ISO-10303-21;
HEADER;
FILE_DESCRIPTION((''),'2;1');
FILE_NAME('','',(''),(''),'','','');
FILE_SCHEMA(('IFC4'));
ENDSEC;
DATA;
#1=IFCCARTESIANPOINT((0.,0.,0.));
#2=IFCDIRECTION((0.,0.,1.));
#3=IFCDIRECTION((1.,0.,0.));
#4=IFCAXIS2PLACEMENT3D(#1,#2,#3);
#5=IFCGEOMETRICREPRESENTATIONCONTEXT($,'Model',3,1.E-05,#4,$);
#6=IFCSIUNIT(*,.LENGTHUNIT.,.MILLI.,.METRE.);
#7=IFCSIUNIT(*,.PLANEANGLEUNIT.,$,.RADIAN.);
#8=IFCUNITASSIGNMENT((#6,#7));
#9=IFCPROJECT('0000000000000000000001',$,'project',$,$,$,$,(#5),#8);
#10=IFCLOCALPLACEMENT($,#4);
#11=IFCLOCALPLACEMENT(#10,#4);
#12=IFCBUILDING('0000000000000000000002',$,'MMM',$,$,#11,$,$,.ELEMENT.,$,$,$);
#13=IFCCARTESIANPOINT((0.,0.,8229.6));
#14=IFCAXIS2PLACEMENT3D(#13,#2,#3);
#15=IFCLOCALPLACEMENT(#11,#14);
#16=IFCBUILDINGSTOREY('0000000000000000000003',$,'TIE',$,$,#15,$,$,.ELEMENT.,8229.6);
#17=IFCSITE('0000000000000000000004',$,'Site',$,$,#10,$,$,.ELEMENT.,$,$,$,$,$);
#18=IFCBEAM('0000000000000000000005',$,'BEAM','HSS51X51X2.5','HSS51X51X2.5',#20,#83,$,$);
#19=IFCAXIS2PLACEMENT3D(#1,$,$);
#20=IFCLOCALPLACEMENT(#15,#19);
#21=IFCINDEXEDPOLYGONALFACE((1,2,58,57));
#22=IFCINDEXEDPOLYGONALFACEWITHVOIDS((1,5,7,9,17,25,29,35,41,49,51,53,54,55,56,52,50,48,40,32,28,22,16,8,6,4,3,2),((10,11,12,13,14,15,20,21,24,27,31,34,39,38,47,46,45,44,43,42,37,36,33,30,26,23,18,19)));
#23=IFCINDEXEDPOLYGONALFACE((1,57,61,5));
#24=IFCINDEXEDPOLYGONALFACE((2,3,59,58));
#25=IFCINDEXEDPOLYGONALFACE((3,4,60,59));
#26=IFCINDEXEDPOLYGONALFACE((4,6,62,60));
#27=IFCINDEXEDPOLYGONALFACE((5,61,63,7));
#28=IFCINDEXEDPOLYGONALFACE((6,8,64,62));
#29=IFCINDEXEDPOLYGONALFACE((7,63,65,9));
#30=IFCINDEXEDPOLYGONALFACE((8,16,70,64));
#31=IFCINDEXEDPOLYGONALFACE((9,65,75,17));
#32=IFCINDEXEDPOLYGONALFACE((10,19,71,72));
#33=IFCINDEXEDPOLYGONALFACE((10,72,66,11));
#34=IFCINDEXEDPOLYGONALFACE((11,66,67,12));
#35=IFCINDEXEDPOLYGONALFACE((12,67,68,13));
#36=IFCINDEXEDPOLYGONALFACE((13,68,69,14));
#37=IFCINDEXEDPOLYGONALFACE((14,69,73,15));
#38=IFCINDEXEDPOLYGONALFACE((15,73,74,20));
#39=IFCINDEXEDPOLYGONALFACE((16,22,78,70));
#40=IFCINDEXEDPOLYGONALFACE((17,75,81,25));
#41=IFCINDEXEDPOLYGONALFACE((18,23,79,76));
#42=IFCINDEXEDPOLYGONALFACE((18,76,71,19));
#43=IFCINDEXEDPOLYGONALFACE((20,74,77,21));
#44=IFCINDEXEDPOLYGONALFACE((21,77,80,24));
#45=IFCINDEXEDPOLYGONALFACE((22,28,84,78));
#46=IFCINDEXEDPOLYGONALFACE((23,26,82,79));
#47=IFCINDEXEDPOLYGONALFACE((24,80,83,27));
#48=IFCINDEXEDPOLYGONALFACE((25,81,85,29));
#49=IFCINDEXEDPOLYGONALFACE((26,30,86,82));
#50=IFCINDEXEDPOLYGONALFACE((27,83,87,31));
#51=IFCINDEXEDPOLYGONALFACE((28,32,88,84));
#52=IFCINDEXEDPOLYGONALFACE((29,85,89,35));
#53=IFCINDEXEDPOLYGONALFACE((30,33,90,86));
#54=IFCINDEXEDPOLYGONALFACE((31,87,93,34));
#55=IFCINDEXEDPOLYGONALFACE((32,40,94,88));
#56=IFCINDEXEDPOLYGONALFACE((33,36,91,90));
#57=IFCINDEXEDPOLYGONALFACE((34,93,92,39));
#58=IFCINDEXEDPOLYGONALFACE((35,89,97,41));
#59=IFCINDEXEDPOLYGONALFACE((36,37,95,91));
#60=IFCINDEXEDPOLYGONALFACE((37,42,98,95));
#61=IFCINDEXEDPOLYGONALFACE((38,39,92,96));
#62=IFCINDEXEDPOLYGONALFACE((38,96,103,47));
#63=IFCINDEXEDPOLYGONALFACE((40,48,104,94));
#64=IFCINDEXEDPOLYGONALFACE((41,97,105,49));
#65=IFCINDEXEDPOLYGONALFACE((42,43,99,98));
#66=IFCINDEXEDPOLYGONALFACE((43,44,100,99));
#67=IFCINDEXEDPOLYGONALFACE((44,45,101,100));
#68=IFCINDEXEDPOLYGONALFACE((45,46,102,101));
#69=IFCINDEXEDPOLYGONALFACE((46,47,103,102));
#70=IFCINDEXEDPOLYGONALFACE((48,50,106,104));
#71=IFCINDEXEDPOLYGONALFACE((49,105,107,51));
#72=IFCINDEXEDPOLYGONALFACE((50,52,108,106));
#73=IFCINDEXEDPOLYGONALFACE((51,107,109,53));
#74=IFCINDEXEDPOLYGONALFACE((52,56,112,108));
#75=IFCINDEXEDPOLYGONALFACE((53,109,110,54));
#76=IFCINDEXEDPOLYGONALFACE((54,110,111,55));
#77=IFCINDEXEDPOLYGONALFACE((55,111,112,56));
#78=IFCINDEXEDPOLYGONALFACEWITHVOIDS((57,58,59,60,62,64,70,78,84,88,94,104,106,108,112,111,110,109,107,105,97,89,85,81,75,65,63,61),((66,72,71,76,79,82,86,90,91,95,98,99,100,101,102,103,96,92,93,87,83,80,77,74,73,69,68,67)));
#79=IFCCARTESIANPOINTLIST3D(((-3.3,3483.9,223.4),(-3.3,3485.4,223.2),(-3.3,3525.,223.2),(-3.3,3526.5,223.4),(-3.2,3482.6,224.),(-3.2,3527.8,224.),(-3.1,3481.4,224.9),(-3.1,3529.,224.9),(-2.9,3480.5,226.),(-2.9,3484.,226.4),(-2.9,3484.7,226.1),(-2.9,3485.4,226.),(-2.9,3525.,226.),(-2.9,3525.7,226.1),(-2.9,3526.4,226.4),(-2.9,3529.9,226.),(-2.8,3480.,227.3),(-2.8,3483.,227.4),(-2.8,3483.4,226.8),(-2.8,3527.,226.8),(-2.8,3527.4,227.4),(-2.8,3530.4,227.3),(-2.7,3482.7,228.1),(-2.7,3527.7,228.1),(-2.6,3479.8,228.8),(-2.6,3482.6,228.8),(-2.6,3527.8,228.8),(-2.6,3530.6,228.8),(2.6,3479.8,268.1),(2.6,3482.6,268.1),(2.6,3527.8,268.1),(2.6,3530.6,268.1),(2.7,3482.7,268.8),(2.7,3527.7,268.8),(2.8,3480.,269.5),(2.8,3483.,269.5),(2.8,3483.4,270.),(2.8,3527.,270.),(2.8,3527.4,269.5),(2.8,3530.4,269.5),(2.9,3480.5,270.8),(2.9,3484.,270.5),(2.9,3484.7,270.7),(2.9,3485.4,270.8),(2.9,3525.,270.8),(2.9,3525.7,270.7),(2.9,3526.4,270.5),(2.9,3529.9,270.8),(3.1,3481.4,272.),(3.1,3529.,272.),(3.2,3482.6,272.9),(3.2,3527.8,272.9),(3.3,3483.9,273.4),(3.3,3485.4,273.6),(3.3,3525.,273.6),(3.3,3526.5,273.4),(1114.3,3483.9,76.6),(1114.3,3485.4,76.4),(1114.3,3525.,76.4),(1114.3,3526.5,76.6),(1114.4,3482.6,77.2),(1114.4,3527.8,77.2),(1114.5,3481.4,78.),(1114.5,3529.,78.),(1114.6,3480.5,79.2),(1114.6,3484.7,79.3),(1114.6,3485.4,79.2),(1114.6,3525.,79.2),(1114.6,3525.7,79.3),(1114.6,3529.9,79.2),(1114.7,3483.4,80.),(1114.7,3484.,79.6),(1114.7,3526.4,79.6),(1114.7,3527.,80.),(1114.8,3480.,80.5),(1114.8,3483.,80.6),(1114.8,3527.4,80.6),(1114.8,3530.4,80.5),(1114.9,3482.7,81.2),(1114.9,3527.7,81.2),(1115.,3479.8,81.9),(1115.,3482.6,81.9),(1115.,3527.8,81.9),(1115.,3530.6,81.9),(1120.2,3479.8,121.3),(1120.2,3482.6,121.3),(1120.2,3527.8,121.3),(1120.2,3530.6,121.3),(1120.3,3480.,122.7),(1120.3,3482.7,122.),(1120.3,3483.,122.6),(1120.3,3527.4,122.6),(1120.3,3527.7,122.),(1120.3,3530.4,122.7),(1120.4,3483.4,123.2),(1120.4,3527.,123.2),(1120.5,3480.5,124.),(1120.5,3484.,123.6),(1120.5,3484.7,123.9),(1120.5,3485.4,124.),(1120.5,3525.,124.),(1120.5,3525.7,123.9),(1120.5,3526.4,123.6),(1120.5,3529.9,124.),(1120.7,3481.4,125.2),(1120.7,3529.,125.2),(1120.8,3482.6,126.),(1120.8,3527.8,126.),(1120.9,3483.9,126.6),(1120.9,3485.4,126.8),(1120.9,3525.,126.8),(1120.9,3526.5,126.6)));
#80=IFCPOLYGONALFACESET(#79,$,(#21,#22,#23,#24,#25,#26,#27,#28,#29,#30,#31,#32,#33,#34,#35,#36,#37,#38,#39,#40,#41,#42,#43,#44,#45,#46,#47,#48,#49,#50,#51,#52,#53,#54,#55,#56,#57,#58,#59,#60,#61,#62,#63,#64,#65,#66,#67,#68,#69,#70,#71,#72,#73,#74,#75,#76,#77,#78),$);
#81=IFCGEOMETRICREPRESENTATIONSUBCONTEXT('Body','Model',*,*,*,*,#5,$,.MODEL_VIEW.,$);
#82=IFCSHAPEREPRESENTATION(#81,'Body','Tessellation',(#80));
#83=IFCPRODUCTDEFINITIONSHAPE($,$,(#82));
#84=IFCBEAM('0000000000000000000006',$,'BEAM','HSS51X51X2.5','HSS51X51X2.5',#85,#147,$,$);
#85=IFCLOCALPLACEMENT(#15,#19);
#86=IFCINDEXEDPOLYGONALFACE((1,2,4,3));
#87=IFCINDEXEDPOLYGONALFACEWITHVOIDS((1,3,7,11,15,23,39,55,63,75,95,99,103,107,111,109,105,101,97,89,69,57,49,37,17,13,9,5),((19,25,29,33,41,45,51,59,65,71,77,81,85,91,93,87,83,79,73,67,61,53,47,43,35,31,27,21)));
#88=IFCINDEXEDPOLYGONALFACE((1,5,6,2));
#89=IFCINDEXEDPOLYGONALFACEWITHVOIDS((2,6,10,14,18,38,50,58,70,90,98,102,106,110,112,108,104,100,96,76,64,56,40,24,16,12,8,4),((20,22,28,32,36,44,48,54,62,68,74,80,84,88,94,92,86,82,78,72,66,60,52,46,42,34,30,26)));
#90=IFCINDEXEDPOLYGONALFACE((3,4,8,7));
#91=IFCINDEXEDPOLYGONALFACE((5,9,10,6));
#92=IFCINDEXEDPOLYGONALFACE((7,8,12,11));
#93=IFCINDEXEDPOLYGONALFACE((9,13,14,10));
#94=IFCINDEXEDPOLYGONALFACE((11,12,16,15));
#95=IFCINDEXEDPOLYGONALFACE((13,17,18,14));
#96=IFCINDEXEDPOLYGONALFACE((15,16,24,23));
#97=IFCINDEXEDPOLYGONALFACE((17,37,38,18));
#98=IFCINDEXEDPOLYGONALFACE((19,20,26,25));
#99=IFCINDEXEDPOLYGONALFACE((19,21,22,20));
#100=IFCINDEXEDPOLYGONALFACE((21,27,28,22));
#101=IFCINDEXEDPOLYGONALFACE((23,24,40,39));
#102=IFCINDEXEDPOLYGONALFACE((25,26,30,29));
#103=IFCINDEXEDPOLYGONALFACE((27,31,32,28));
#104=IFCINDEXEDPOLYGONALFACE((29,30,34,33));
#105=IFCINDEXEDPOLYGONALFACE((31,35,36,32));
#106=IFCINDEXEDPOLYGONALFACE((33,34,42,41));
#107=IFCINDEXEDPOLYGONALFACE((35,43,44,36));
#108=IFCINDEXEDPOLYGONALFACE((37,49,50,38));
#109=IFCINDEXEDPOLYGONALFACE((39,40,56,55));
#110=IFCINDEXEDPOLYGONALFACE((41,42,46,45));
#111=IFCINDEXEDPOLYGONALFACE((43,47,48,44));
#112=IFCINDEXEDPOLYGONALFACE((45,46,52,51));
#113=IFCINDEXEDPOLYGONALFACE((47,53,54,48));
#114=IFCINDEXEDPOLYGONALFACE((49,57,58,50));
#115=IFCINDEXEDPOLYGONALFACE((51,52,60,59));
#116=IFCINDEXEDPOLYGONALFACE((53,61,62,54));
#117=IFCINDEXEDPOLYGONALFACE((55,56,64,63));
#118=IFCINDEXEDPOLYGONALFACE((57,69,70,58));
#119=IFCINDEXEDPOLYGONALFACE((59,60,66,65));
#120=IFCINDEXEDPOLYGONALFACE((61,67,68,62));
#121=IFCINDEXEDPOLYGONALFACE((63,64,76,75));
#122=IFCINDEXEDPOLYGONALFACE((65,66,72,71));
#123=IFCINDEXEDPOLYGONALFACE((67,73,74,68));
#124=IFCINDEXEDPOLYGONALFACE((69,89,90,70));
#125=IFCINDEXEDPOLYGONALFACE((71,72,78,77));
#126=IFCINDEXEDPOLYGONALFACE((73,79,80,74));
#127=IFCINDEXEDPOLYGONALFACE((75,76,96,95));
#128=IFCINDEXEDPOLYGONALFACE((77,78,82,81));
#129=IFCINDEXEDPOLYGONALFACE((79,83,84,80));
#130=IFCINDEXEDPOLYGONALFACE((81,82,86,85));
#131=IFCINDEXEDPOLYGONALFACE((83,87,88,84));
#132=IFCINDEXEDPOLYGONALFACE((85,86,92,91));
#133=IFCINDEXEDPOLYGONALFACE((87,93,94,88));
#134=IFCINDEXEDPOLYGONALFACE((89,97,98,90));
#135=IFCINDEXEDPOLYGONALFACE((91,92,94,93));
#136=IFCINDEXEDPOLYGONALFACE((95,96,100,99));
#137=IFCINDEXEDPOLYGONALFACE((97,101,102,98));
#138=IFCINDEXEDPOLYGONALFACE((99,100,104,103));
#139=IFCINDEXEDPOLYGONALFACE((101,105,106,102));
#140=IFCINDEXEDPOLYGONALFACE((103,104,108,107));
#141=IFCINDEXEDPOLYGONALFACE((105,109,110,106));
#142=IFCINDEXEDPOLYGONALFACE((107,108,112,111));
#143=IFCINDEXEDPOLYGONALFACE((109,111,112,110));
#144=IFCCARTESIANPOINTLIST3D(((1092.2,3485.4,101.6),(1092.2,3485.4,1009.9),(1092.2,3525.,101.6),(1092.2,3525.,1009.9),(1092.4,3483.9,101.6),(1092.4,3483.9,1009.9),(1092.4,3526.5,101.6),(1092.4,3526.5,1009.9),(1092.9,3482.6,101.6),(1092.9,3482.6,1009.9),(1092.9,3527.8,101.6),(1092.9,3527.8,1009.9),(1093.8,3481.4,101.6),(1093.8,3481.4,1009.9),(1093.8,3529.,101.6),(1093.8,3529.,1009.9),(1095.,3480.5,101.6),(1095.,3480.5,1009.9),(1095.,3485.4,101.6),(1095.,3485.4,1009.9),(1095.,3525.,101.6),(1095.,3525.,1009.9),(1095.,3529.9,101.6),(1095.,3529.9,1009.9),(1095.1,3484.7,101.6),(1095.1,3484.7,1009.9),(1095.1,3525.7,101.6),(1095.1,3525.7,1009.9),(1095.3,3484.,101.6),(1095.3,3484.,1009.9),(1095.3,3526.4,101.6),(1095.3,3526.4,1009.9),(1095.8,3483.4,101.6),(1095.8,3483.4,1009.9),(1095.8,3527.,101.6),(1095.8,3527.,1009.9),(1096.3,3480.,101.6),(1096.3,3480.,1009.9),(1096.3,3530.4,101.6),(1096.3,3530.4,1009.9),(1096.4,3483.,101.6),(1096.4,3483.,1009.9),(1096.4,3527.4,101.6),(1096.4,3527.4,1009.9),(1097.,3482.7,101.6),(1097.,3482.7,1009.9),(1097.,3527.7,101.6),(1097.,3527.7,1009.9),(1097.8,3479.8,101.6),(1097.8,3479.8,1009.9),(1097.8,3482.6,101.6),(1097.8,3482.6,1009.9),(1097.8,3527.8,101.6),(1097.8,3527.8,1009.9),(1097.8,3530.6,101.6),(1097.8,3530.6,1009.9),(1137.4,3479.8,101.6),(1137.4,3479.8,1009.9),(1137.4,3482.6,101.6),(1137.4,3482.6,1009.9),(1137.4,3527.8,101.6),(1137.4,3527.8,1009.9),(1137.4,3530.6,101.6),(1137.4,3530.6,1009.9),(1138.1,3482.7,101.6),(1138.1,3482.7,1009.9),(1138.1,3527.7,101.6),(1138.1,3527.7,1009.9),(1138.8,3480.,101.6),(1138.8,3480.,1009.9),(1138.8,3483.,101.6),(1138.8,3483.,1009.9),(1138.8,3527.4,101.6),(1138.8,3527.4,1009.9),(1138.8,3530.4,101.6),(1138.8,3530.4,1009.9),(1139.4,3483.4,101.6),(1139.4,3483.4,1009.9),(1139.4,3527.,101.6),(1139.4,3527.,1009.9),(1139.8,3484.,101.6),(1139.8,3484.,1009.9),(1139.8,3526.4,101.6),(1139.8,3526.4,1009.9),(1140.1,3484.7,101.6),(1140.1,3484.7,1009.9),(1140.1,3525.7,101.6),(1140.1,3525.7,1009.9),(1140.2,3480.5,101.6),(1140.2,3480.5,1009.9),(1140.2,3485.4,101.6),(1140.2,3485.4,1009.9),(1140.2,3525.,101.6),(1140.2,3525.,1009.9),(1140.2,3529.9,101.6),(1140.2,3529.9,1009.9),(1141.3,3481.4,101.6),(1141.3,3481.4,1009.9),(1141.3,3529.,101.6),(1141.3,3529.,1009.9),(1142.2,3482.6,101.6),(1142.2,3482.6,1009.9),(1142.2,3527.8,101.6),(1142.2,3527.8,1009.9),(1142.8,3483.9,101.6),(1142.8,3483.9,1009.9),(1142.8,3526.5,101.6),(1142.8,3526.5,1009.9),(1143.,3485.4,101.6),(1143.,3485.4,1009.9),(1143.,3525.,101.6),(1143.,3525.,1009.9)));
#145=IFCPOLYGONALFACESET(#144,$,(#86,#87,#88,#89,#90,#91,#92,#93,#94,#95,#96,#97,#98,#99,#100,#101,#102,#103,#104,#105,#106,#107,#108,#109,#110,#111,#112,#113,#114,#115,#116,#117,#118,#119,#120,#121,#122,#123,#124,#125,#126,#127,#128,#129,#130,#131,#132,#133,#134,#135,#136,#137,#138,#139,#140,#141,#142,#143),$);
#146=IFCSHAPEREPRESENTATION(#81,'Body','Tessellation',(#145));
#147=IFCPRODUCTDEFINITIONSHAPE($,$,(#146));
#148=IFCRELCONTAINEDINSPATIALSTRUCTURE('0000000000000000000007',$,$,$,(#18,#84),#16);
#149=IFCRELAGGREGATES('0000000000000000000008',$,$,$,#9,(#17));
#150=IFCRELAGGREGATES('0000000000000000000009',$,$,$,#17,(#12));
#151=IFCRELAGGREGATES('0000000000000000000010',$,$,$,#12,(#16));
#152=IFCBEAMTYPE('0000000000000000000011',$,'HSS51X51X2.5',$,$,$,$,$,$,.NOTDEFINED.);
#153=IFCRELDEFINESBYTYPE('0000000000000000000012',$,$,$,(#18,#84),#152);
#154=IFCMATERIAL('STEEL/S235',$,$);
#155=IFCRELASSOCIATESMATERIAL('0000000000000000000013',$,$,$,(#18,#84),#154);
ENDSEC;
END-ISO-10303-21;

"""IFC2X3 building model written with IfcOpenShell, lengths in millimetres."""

from ifc_helpers import new_model, si_unit, frame, origin_with_axes, origin_2d_with_axis, place, context, subcontext, project, spatial, hollow_rectangle, extrude, material, type_object, element, save


model = new_model("IFC2X3")

# Units and contexts
model_context = context("Model", 3, precision=1e-05, world=origin_with_axes())
body_context = subcontext(model_context, "Body", "Model", "MODEL_VIEW")
ifc_project = project(units=[si_unit("LENGTHUNIT", "METRE", prefix="MILLI"), si_unit("PLANEANGLEUNIT", "RADIAN")], contexts=[model_context])

# Site, building, storey
site_placement = place(None, origin_with_axes())
site = spatial("IfcSite", under=ifc_project, at=site_placement, Name="Site", CompositionType="ELEMENT")
building_placement = place(site_placement, origin_with_axes())
building = spatial("IfcBuilding", under=site, at=building_placement, Name="MMM", CompositionType="ELEMENT")
storey_placement = place(building_placement, frame((0.0, 0.0, 8229.6), z_axis=(0.0, 0.0, 1.0), x_axis=(1.0, 0.0, 0.0)))
storey = spatial("IfcBuildingStorey", under=building, at=storey_placement, Name="TIE", CompositionType="ELEMENT", Elevation=8229.6)

# Beams
ifc_material = material(Name="STEEL/S235")
beam_type_1 = type_object("IfcBeamType", Name="HSS51X51X2.5", PredefinedType="NOTDEFINED")
beam_1_placement = place(storey_placement, frame((1117.6, 3505.2, 101.6), z_axis=(0.130258, 0.0, 0.99148), x_axis=(-0.99148, 0.0, 0.130258)))
element("IfcBeam", 1, at=beam_1_placement, inside=storey, type_object=beam_type_1, material=ifc_material, Name="BEAM", Description="HSS51X51X2.5", ObjectType="HSS51X51X2.5", context=body_context, shape_type="SweptSolid", body=[
    extrude(hollow_rectangle(XDim=50.8, YDim=50.8, WallThickness=2.8, InnerFilletRadius=2.8, OuterFilletRadius=5.6, at=origin_2d_with_axis()), frame((1127.2, 0.0, 0.0), z_axis=(-1.0, 0.0, 0.0), x_axis=(0.0, -1.0, 0.0)), (0.0, 0.0, 1.0), 1127.2),
])
beam_2_placement = place(storey_placement, frame((1117.6, 3505.2, 1009.9), z_axis=(1.0, 0.0, 0.0), x_axis=(0.0, 0.0, -1.0)))
element("IfcBeam", 2, at=beam_2_placement, inside=storey, type_object=beam_type_1, material=ifc_material, Name="BEAM", Description="HSS51X51X2.5", ObjectType="HSS51X51X2.5", context=body_context, shape_type="SweptSolid", body=[
    extrude(hollow_rectangle(XDim=50.8, YDim=50.8, WallThickness=2.8, InnerFilletRadius=2.8, OuterFilletRadius=5.6, at=origin_2d_with_axis()), frame((908.3, 0.0, 0.0), z_axis=(-1.0, 0.0, 0.0), x_axis=(0.0, -1.0, 0.0)), (0.0, 0.0, 1.0), 908.3),
])

save(model, "model.ifc")
